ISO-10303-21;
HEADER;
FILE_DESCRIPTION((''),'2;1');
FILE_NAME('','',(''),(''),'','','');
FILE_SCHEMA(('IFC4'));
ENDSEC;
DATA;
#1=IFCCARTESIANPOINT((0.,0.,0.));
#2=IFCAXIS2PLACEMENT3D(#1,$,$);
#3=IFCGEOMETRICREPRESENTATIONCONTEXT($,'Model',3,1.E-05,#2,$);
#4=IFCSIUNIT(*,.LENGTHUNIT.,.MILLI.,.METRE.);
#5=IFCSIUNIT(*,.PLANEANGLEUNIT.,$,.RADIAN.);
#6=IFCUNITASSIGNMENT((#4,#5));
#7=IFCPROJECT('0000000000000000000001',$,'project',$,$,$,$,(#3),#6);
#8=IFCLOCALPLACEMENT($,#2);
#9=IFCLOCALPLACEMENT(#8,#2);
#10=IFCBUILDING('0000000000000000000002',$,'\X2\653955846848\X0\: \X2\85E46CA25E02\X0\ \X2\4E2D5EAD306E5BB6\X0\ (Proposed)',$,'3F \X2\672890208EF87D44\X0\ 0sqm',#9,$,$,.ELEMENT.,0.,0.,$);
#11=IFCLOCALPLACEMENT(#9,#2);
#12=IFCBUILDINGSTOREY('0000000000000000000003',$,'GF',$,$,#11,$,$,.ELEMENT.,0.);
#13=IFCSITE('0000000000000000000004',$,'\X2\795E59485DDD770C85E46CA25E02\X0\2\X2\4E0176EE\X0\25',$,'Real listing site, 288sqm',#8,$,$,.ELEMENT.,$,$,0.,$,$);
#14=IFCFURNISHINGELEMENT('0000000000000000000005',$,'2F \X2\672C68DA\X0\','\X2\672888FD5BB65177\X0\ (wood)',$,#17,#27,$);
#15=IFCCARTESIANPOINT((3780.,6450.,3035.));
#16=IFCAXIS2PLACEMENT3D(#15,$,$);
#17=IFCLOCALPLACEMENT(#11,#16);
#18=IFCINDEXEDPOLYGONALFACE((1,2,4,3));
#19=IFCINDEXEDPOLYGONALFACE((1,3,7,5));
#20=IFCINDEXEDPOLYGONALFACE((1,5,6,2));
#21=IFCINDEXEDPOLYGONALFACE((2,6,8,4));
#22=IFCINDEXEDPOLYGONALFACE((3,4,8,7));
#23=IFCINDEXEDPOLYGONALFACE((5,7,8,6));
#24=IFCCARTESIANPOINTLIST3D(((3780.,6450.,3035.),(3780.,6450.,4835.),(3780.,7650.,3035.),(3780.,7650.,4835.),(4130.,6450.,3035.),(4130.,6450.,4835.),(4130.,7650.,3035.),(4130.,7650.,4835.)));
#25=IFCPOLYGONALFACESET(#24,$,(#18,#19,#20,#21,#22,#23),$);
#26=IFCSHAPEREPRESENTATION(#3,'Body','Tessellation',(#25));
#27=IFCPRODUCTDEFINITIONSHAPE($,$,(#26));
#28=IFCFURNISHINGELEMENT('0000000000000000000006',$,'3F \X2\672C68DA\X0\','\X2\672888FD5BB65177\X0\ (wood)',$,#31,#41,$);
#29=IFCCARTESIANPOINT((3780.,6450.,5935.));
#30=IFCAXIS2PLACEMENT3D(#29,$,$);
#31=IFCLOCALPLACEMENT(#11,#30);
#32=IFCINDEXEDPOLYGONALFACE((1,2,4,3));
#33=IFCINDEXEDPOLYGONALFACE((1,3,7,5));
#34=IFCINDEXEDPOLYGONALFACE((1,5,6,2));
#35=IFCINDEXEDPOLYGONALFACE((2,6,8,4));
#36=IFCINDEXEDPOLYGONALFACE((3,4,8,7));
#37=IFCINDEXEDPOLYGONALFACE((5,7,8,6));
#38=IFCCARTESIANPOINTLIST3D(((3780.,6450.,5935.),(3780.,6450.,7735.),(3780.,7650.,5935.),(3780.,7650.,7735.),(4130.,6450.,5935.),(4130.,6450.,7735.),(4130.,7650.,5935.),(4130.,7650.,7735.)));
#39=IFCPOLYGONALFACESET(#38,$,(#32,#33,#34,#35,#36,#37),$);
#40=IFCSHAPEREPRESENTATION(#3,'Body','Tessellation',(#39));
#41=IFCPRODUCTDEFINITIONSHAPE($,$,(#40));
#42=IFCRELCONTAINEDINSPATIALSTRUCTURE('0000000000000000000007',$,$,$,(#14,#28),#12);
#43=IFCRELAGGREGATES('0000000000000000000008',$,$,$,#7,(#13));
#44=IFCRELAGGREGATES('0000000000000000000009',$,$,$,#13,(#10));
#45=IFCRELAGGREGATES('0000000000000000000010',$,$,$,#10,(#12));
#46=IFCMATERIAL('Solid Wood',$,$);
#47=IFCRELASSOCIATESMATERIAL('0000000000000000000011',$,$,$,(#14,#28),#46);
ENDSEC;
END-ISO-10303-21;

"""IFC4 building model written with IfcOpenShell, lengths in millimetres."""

from ifc_helpers import new_model, si_unit, frame, frame_2d, origin, place, context, project, spatial, rectangle, extrude, material, element, save


model = new_model("IFC4")

# Units and contexts
model_context = context("Model", 3, precision=1e-05, world=origin())
ifc_project = project(units=[si_unit("LENGTHUNIT", "METRE", prefix="MILLI"), si_unit("PLANEANGLEUNIT", "RADIAN")], contexts=[model_context])

# Site, building, storey
site_placement = place(None, origin())
site = spatial("IfcSite", under=ifc_project, at=site_placement, Name="神奈川県藤沢市2丁目25", ObjectType="Real listing site, 288sqm", CompositionType="ELEMENT", RefElevation=0.0)
building_placement = place(site_placement, origin())
building = spatial("IfcBuilding", under=site, at=building_placement, Name="改善案: 藤沢市 中庭の家 (Proposed)", ObjectType="3F 木造軸組 0sqm", CompositionType="ELEMENT", ElevationOfRefHeight=0.0, ElevationOfTerrain=0.0)
storey_placement = place(building_placement, origin())
storey = spatial("IfcBuildingStorey", under=building, at=storey_placement, Name="GF", CompositionType="ELEMENT", Elevation=0.0)

# Shared definitions
ifc_material_1 = material(Name="Solid Wood")

# Furnishing elements
furnishing_1_placement = place(storey_placement, frame((3780.0, 6450.0, 3035.0)))
element("IfcFurnishingElement", 1, at=furnishing_1_placement, inside=storey, material=ifc_material_1, Name="2F 本棚", Description="木製家具 (wood)", context=model_context, shape_type="SweptSolid", body=[
    extrude(rectangle(XDim=350.0, YDim=1200.0, at=frame_2d((175.0, 600.0))), frame((3780.0, 6450.0, 3035.0)), (0.0, 0.0, 1.0), 1800.0),
])
furnishing_2_placement = place(storey_placement, frame((3780.0, 6450.0, 5935.0)))
element("IfcFurnishingElement", 2, at=furnishing_2_placement, inside=storey, material=ifc_material_1, Name="3F 本棚", Description="木製家具 (wood)", context=model_context, shape_type="SweptSolid", body=[
    extrude(rectangle(XDim=350.0, YDim=1200.0, at=frame_2d((175.0, 600.0))), frame((3780.0, 6450.0, 5935.0)), (0.0, 0.0, 1.0), 1800.0),
])

save(model, "model.ifc")
